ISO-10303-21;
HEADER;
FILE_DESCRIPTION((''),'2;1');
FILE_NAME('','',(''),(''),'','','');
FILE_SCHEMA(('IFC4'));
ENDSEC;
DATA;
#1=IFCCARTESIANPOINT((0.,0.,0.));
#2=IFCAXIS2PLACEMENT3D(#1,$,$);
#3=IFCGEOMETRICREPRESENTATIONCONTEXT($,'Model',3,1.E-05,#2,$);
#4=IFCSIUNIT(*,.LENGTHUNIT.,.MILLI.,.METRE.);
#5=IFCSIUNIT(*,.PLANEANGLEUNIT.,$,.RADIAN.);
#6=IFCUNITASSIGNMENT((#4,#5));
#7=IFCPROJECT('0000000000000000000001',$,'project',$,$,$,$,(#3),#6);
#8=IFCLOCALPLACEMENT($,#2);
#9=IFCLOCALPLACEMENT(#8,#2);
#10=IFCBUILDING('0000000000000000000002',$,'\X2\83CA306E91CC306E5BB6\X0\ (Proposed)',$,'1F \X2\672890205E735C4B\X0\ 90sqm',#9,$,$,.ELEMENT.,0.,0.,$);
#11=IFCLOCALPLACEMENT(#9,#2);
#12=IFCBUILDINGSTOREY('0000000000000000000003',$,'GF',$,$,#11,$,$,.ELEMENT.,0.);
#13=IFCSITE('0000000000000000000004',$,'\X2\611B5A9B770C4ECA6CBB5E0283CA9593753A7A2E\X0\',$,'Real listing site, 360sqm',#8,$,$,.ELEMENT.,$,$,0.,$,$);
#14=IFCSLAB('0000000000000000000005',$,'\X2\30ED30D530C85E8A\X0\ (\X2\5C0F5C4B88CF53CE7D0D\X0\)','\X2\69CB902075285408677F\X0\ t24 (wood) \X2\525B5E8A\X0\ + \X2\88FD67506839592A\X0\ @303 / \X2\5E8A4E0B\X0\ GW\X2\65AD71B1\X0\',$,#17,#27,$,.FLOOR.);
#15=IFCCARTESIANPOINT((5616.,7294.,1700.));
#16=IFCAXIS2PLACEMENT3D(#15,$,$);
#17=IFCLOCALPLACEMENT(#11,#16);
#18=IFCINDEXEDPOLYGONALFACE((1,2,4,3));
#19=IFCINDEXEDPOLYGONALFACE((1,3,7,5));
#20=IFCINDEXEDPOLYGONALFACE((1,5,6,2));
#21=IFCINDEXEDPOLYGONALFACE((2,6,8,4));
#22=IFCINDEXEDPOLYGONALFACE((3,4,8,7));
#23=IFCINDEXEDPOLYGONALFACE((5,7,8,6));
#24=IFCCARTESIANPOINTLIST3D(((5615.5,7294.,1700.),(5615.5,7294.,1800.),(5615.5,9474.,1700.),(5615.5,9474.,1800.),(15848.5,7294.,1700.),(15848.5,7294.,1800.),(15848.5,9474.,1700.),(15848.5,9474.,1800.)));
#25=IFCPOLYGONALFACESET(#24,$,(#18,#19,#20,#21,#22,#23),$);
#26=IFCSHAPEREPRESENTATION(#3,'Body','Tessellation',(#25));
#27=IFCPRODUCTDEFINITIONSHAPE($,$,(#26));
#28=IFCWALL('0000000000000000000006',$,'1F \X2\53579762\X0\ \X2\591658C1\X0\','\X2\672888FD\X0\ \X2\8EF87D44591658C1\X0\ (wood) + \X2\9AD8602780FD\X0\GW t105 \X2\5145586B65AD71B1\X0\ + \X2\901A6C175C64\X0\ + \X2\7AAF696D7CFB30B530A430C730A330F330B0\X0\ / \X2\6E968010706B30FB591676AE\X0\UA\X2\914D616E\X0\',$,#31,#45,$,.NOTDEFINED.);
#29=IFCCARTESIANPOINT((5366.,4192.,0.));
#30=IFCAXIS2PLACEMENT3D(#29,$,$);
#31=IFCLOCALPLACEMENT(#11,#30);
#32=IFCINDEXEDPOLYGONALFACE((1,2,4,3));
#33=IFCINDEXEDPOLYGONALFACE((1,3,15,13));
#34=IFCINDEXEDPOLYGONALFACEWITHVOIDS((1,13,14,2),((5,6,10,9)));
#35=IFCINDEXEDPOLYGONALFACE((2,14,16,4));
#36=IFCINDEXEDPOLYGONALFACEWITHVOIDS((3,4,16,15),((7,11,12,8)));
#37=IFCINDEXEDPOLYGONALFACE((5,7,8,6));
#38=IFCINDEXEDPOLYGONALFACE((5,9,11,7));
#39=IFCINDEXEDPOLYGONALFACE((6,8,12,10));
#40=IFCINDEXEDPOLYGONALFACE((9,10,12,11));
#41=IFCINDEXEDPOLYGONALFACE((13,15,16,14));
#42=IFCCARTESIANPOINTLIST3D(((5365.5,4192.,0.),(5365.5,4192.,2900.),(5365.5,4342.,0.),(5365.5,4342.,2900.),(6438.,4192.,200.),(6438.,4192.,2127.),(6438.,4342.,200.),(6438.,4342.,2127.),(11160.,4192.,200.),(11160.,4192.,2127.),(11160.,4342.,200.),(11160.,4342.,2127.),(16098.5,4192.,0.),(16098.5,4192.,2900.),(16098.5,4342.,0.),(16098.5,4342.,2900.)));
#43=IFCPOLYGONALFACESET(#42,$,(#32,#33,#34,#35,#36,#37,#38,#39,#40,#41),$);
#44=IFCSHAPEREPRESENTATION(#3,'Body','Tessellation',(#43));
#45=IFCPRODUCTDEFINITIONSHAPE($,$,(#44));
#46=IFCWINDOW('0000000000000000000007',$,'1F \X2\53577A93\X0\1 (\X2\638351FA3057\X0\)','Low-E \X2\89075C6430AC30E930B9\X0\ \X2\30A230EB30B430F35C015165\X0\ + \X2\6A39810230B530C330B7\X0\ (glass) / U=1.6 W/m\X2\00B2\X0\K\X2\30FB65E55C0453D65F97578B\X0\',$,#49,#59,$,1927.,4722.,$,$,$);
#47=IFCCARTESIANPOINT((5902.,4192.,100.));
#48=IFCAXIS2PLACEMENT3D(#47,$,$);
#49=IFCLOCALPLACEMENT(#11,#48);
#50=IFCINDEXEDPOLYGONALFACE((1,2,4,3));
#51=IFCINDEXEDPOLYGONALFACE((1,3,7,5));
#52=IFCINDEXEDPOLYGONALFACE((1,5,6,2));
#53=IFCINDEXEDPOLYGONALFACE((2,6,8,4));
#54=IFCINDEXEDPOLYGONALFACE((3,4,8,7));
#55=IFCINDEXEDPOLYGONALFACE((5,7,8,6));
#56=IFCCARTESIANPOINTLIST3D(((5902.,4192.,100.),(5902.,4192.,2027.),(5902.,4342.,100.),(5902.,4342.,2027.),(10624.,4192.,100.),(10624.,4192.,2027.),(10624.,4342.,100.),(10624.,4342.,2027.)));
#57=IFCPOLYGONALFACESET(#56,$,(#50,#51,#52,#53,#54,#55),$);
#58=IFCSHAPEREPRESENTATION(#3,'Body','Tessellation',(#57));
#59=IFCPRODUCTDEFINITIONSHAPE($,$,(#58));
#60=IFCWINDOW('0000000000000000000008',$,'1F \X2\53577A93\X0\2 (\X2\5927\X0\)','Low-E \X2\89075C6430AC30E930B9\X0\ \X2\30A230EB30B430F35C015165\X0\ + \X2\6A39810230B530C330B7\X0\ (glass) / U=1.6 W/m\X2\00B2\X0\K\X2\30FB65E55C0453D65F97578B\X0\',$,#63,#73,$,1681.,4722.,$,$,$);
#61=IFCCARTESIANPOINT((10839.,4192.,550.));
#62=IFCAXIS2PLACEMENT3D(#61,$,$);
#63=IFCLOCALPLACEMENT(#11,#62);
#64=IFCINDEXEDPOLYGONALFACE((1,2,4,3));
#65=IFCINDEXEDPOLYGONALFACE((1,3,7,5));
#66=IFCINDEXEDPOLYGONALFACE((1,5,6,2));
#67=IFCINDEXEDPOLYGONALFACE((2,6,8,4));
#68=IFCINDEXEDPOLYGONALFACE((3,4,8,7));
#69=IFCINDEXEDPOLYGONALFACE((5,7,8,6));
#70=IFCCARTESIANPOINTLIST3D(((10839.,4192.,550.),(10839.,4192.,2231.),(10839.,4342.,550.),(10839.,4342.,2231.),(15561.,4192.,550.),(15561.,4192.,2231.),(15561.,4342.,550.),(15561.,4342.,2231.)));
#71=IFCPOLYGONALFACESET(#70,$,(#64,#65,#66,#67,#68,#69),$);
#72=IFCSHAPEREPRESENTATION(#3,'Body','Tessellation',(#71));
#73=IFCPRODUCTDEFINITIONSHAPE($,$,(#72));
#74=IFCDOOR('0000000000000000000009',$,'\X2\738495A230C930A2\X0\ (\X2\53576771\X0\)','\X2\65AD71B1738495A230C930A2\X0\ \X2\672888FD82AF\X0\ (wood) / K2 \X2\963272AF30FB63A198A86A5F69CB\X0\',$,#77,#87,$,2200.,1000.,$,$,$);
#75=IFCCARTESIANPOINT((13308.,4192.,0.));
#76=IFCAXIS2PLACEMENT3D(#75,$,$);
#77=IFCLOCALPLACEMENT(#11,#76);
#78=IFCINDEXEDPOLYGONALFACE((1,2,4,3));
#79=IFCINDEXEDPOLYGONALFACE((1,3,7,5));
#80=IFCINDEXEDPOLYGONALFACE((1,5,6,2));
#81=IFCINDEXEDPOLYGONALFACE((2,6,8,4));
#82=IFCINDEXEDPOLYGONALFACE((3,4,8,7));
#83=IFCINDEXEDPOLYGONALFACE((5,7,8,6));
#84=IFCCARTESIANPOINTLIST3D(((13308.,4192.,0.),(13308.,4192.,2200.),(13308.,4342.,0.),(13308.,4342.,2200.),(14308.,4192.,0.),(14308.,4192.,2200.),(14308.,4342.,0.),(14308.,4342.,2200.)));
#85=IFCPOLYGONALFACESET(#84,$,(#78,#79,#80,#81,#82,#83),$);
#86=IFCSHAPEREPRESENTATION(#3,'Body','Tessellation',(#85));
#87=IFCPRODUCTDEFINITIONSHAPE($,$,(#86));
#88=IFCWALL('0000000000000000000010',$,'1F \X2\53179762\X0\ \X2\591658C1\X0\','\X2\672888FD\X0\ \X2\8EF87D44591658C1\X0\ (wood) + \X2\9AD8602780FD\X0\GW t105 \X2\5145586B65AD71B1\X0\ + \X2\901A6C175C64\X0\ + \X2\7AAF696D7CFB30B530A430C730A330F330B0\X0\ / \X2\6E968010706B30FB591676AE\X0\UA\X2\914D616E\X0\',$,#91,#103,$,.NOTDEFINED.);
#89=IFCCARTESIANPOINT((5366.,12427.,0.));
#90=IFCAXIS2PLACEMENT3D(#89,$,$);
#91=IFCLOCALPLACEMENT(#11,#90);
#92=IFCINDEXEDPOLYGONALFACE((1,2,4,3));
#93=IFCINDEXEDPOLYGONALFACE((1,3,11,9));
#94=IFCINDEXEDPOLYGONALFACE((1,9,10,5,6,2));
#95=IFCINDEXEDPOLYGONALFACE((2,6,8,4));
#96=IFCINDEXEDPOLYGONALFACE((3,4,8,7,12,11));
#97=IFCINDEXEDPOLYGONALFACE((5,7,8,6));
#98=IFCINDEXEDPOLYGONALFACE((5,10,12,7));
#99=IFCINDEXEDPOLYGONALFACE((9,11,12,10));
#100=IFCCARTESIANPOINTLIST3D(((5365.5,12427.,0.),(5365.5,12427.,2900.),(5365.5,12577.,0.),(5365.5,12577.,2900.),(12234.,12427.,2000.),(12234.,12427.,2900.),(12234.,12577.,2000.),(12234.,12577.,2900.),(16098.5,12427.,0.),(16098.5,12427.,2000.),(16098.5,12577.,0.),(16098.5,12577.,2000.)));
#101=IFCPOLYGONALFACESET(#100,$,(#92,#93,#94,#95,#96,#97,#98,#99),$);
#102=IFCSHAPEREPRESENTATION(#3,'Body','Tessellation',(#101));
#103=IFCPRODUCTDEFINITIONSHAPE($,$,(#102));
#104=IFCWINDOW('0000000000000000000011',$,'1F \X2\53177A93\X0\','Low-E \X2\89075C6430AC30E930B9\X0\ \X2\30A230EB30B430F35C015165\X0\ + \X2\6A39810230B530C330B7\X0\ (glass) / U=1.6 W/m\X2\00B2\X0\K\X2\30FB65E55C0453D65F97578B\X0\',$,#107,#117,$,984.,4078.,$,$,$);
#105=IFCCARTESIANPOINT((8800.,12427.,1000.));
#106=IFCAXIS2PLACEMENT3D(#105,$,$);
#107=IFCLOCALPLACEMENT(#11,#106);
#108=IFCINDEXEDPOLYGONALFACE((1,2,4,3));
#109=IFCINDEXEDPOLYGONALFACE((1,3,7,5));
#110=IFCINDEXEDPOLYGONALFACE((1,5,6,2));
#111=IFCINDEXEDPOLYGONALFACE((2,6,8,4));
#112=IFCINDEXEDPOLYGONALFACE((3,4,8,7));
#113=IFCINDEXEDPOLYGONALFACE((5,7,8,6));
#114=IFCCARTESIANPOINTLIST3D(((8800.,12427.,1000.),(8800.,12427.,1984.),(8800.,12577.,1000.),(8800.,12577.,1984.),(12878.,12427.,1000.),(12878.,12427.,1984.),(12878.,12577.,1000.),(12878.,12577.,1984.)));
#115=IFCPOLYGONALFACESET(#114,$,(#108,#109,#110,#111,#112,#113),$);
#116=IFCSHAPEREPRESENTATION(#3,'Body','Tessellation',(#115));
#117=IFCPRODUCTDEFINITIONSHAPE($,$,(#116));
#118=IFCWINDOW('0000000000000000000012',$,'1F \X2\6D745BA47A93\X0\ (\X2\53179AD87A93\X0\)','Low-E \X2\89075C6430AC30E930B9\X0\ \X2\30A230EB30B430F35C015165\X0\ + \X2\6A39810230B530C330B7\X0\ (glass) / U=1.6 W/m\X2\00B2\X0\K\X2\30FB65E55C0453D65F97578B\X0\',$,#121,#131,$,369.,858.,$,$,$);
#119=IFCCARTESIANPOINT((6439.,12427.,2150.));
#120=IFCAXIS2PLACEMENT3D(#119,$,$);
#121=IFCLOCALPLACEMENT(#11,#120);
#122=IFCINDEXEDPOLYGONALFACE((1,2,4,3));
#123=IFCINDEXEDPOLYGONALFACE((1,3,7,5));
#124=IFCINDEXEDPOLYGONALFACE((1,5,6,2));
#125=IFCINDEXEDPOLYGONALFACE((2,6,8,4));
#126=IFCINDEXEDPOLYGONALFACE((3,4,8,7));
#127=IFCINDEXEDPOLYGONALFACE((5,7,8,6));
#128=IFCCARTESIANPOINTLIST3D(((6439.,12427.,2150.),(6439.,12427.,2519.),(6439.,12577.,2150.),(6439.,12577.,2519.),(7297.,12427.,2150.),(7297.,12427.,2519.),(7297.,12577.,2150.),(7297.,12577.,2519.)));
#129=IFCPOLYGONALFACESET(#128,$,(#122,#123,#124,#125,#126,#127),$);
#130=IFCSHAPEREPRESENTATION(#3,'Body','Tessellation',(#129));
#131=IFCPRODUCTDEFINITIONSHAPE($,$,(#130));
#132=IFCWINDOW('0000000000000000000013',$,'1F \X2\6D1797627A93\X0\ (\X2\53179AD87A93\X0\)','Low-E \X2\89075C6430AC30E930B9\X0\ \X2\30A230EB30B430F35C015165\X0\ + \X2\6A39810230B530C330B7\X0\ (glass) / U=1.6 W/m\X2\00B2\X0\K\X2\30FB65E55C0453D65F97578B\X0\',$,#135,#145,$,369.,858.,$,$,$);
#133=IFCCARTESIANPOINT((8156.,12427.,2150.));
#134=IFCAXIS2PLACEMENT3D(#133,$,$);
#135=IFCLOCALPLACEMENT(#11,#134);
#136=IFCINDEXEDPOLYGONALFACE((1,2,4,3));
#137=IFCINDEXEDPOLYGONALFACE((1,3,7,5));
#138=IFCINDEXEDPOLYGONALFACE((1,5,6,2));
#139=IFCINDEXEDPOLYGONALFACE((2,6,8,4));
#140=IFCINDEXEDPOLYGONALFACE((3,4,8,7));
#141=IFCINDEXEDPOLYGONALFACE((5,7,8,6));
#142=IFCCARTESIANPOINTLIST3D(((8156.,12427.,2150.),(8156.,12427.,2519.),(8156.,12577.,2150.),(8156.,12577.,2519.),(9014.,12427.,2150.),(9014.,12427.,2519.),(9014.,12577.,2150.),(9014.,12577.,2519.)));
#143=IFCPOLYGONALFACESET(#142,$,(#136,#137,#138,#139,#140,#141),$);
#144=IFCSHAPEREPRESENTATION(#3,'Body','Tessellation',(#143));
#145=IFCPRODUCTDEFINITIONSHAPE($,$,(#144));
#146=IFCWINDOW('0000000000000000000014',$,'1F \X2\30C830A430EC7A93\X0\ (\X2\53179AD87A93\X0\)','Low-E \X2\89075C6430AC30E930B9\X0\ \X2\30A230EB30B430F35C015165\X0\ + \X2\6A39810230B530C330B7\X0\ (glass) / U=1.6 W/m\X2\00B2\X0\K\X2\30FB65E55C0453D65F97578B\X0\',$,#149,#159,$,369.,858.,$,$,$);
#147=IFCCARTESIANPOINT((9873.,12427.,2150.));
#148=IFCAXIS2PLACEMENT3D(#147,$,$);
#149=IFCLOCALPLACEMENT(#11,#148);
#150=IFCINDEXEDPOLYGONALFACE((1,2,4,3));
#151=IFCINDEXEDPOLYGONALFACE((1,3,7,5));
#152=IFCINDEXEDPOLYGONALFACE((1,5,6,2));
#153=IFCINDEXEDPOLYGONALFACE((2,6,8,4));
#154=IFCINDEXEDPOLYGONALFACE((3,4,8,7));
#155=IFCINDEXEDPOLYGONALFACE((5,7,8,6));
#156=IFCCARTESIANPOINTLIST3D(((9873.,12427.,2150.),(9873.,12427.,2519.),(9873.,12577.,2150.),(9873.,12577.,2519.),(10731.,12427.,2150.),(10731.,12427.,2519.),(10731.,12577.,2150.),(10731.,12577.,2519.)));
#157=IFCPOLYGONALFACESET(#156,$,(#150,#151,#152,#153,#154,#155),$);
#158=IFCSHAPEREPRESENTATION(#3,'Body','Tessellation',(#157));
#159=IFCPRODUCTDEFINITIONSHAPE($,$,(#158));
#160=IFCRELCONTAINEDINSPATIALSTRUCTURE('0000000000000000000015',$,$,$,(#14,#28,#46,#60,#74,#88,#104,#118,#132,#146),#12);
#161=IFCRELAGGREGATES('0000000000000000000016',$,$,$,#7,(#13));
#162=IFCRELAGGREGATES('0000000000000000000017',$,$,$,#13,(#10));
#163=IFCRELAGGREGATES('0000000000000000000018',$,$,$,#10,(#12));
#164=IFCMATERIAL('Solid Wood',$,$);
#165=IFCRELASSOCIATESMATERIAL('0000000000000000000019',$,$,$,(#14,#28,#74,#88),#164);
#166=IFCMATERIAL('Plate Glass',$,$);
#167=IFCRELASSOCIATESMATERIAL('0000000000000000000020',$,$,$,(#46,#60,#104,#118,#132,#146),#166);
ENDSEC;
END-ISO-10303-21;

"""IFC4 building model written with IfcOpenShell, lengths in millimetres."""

from ifc_helpers import new_model, si_unit, frame, frame_2d, origin, place, context, project, spatial, rectangle, extrude, material, element, fill, save


model = new_model("IFC4")

# Units and contexts
model_context = context("Model", 3, precision=1e-05, world=origin())
ifc_project = project(units=[si_unit("LENGTHUNIT", "METRE", prefix="MILLI"), si_unit("PLANEANGLEUNIT", "RADIAN")], contexts=[model_context])

# Site, building, storey
site_placement = place(None, origin())
site = spatial("IfcSite", under=ifc_project, at=site_placement, Name="愛媛県今治市菊間町種", ObjectType="Real listing site, 360sqm", CompositionType="ELEMENT", RefElevation=0.0)
building_placement = place(site_placement, origin())
building = spatial("IfcBuilding", under=site, at=building_placement, Name="菊の里の家 (Proposed)", ObjectType="1F 木造平屋 90sqm", CompositionType="ELEMENT", ElevationOfRefHeight=0.0, ElevationOfTerrain=0.0)
storey_placement = place(building_placement, origin())
storey = spatial("IfcBuildingStorey", under=building, at=storey_placement, Name="GF", CompositionType="ELEMENT", Elevation=0.0)

# Slab
ifc_material_1 = material(Name="Solid Wood")
slab_1_placement = place(storey_placement, frame((5616.0, 7294.0, 1700.0)))
element("IfcSlab", 1, at=slab_1_placement, inside=storey, material=ifc_material_1, Name="ロフト床 (小屋裏収納)", Description="構造用合板 t24 (wood) 剛床 + 製材根太 @303 / 床下 GW断熱", PredefinedType="FLOOR", context=model_context, shape_type="SweptSolid", body=[
    extrude(rectangle(XDim=10233.0, YDim=2180.0, at=frame_2d((5116.0, 1090.0))), frame((5616.0, 7294.0, 1700.0)), (0.0, 0.0, 1.0), 100.0),
])

# Wall, openings, windows, door
wall_1_placement = place(storey_placement, frame((5366.0, 4192.0, 0.0)))
wall_1 = element("IfcWall", 2, at=wall_1_placement, inside=storey, material=ifc_material_1, Name="1F 南面 外壁", Description="木製 軸組外壁 (wood) + 高性能GW t105 充填断熱 + 通気層 + 窯業系サイディング / 準耐火・外皮UA配慮", PredefinedType="NOTDEFINED", context=model_context, shape_type="SweptSolid", body=[
    extrude(rectangle(XDim=10733.0, YDim=150.0, at=frame_2d((5366.0, 75.0))), frame((5366.0, 4192.0, 0.0)), (0.0, 0.0, 1.0), 2900.0),
])
opening_1_placement = place(storey_placement, frame((5902.0, 4192.0, 100.0)))
opening_1 = element("IfcOpeningElement", 3, at=opening_1_placement, cuts=wall_1, PredefinedType="NOTDEFINED", context=model_context, shape_type="SweptSolid", body=[
    extrude(rectangle(XDim=4722.0, YDim=150.0, at=frame_2d((2361.0, 75.0))), frame((5902.0, 4192.0, 100.0)), (0.0, 0.0, 1.0), 1927.0),
])
opening_2_placement = place(storey_placement, frame((10839.0, 4192.0, 550.0)))
opening_2 = element("IfcOpeningElement", 4, at=opening_2_placement, cuts=wall_1, PredefinedType="NOTDEFINED", context=model_context, shape_type="SweptSolid", body=[
    extrude(rectangle(XDim=4722.0, YDim=150.0, at=frame_2d((2361.0, 75.0))), frame((10839.0, 4192.0, 550.0)), (0.0, 0.0, 1.0), 1681.0),
])
opening_3_placement = place(storey_placement, frame((13308.0, 4192.0, 0.0)))
opening_3 = element("IfcOpeningElement", 5, at=opening_3_placement, cuts=wall_1, PredefinedType="NOTDEFINED", context=model_context, shape_type="SweptSolid", body=[
    extrude(rectangle(XDim=1000.0, YDim=150.0, at=frame_2d((500.0, 75.0))), frame((13308.0, 4192.0, 0.0)), (0.0, 0.0, 1.0), 2200.0),
])
ifc_material_2 = material(Name="Plate Glass")
window_1_placement = place(storey_placement, frame((5902.0, 4192.0, 100.0)))
window_1 = element("IfcWindow", 6, at=window_1_placement, inside=storey, material=ifc_material_2, Name="1F 南窓1 (掃出し)", Description="Low-E 複層ガラス アルゴン封入 + 樹脂サッシ (glass) / U=1.6 W/m²K・日射取得型", OverallHeight=1927.0, OverallWidth=4722.0, context=model_context, shape_type="SweptSolid", body=[
    extrude(rectangle(XDim=4722.0, YDim=150.0, at=frame_2d((2361.0, 75.0))), frame((5902.0, 4192.0, 100.0)), (0.0, 0.0, 1.0), 1927.0),
])
fill(opening_1, window_1)
window_2_placement = place(storey_placement, frame((10839.0, 4192.0, 550.0)))
window_2 = element("IfcWindow", 7, at=window_2_placement, inside=storey, material=ifc_material_2, Name="1F 南窓2 (大)", Description="Low-E 複層ガラス アルゴン封入 + 樹脂サッシ (glass) / U=1.6 W/m²K・日射取得型", OverallHeight=1681.0, OverallWidth=4722.0, context=model_context, shape_type="SweptSolid", body=[
    extrude(rectangle(XDim=4722.0, YDim=150.0, at=frame_2d((2361.0, 75.0))), frame((10839.0, 4192.0, 550.0)), (0.0, 0.0, 1.0), 1681.0),
])
fill(opening_2, window_2)
door_1_placement = place(storey_placement, frame((13308.0, 4192.0, 0.0)))
door_1 = element("IfcDoor", 8, at=door_1_placement, inside=storey, material=ifc_material_1, Name="玄関ドア (南東)", Description="断熱玄関ドア 木製芯 (wood) / K2 防犯・採風機構", OverallHeight=2200.0, OverallWidth=1000.0, context=model_context, shape_type="SweptSolid", body=[
    extrude(rectangle(XDim=1000.0, YDim=150.0, at=frame_2d((500.0, 75.0))), frame((13308.0, 4192.0, 0.0)), (0.0, 0.0, 1.0), 2200.0),
])
fill(opening_3, door_1)

# Wall, openings, windows
wall_2_placement = place(storey_placement, frame((5366.0, 12427.0, 0.0)))
wall_2 = element("IfcWall", 9, at=wall_2_placement, inside=storey, material=ifc_material_1, Name="1F 北面 外壁", Description="木製 軸組外壁 (wood) + 高性能GW t105 充填断熱 + 通気層 + 窯業系サイディング / 準耐火・外皮UA配慮", PredefinedType="NOTDEFINED", context=model_context, shape_type="SweptSolid", body=[
    extrude(rectangle(XDim=10733.0, YDim=150.0, at=frame_2d((5366.0, 75.0))), frame((5366.0, 12427.0, 0.0)), (0.0, 0.0, 1.0), 2900.0),
])
opening_4_placement = place(storey_placement, frame((8800.0, 12427.0, 1000.0)))
opening_4 = element("IfcOpeningElement", 10, at=opening_4_placement, cuts=wall_2, PredefinedType="NOTDEFINED", context=model_context, shape_type="SweptSolid", body=[
    extrude(rectangle(XDim=4078.0, YDim=150.0, at=frame_2d((2039.0, 75.0))), frame((8800.0, 12427.0, 1000.0)), (0.0, 0.0, 1.0), 984.0),
])
opening_5_placement = place(storey_placement, frame((6439.0, 12427.0, 2150.0)))
opening_5 = element("IfcOpeningElement", 11, at=opening_5_placement, cuts=wall_2, PredefinedType="NOTDEFINED", context=model_context, shape_type="SweptSolid", body=[
    extrude(rectangle(XDim=858.0, YDim=150.0, at=frame_2d((429.0, 75.0))), frame((6439.0, 12427.0, 2150.0)), (0.0, 0.0, 1.0), 369.0),
])
opening_6_placement = place(storey_placement, frame((8156.0, 12427.0, 2150.0)))
opening_6 = element("IfcOpeningElement", 12, at=opening_6_placement, cuts=wall_2, PredefinedType="NOTDEFINED", context=model_context, shape_type="SweptSolid", body=[
    extrude(rectangle(XDim=858.0, YDim=150.0, at=frame_2d((429.0, 75.0))), frame((8156.0, 12427.0, 2150.0)), (0.0, 0.0, 1.0), 369.0),
])
opening_7_placement = place(storey_placement, frame((9873.0, 12427.0, 2150.0)))
opening_7 = element("IfcOpeningElement", 13, at=opening_7_placement, cuts=wall_2, PredefinedType="NOTDEFINED", context=model_context, shape_type="SweptSolid", body=[
    extrude(rectangle(XDim=858.0, YDim=150.0, at=frame_2d((429.0, 75.0))), frame((9873.0, 12427.0, 2150.0)), (0.0, 0.0, 1.0), 369.0),
])
window_3_placement = place(storey_placement, frame((8800.0, 12427.0, 1000.0)))
window_3 = element("IfcWindow", 14, at=window_3_placement, inside=storey, material=ifc_material_2, Name="1F 北窓", Description="Low-E 複層ガラス アルゴン封入 + 樹脂サッシ (glass) / U=1.6 W/m²K・日射取得型", OverallHeight=984.0, OverallWidth=4078.0, context=model_context, shape_type="SweptSolid", body=[
    extrude(rectangle(XDim=4078.0, YDim=150.0, at=frame_2d((2039.0, 75.0))), frame((8800.0, 12427.0, 1000.0)), (0.0, 0.0, 1.0), 984.0),
])
fill(opening_4, window_3)
window_4_placement = place(storey_placement, frame((6439.0, 12427.0, 2150.0)))
window_4 = element("IfcWindow", 15, at=window_4_placement, inside=storey, material=ifc_material_2, Name="1F 浴室窓 (北高窓)", Description="Low-E 複層ガラス アルゴン封入 + 樹脂サッシ (glass) / U=1.6 W/m²K・日射取得型", OverallHeight=369.0, OverallWidth=858.0, context=model_context, shape_type="SweptSolid", body=[
    extrude(rectangle(XDim=858.0, YDim=150.0, at=frame_2d((429.0, 75.0))), frame((6439.0, 12427.0, 2150.0)), (0.0, 0.0, 1.0), 369.0),
])
fill(opening_5, window_4)
window_5_placement = place(storey_placement, frame((8156.0, 12427.0, 2150.0)))
window_5 = element("IfcWindow", 16, at=window_5_placement, inside=storey, material=ifc_material_2, Name="1F 洗面窓 (北高窓)", Description="Low-E 複層ガラス アルゴン封入 + 樹脂サッシ (glass) / U=1.6 W/m²K・日射取得型", OverallHeight=369.0, OverallWidth=858.0, context=model_context, shape_type="SweptSolid", body=[
    extrude(rectangle(XDim=858.0, YDim=150.0, at=frame_2d((429.0, 75.0))), frame((8156.0, 12427.0, 2150.0)), (0.0, 0.0, 1.0), 369.0),
])
fill(opening_6, window_5)
window_6_placement = place(storey_placement, frame((9873.0, 12427.0, 2150.0)))
window_6 = element("IfcWindow", 17, at=window_6_placement, inside=storey, material=ifc_material_2, Name="1F トイレ窓 (北高窓)", Description="Low-E 複層ガラス アルゴン封入 + 樹脂サッシ (glass) / U=1.6 W/m²K・日射取得型", OverallHeight=369.0, OverallWidth=858.0, context=model_context, shape_type="SweptSolid", body=[
    extrude(rectangle(XDim=858.0, YDim=150.0, at=frame_2d((429.0, 75.0))), frame((9873.0, 12427.0, 2150.0)), (0.0, 0.0, 1.0), 369.0),
])
fill(opening_7, window_6)

save(model, "model.ifc")
